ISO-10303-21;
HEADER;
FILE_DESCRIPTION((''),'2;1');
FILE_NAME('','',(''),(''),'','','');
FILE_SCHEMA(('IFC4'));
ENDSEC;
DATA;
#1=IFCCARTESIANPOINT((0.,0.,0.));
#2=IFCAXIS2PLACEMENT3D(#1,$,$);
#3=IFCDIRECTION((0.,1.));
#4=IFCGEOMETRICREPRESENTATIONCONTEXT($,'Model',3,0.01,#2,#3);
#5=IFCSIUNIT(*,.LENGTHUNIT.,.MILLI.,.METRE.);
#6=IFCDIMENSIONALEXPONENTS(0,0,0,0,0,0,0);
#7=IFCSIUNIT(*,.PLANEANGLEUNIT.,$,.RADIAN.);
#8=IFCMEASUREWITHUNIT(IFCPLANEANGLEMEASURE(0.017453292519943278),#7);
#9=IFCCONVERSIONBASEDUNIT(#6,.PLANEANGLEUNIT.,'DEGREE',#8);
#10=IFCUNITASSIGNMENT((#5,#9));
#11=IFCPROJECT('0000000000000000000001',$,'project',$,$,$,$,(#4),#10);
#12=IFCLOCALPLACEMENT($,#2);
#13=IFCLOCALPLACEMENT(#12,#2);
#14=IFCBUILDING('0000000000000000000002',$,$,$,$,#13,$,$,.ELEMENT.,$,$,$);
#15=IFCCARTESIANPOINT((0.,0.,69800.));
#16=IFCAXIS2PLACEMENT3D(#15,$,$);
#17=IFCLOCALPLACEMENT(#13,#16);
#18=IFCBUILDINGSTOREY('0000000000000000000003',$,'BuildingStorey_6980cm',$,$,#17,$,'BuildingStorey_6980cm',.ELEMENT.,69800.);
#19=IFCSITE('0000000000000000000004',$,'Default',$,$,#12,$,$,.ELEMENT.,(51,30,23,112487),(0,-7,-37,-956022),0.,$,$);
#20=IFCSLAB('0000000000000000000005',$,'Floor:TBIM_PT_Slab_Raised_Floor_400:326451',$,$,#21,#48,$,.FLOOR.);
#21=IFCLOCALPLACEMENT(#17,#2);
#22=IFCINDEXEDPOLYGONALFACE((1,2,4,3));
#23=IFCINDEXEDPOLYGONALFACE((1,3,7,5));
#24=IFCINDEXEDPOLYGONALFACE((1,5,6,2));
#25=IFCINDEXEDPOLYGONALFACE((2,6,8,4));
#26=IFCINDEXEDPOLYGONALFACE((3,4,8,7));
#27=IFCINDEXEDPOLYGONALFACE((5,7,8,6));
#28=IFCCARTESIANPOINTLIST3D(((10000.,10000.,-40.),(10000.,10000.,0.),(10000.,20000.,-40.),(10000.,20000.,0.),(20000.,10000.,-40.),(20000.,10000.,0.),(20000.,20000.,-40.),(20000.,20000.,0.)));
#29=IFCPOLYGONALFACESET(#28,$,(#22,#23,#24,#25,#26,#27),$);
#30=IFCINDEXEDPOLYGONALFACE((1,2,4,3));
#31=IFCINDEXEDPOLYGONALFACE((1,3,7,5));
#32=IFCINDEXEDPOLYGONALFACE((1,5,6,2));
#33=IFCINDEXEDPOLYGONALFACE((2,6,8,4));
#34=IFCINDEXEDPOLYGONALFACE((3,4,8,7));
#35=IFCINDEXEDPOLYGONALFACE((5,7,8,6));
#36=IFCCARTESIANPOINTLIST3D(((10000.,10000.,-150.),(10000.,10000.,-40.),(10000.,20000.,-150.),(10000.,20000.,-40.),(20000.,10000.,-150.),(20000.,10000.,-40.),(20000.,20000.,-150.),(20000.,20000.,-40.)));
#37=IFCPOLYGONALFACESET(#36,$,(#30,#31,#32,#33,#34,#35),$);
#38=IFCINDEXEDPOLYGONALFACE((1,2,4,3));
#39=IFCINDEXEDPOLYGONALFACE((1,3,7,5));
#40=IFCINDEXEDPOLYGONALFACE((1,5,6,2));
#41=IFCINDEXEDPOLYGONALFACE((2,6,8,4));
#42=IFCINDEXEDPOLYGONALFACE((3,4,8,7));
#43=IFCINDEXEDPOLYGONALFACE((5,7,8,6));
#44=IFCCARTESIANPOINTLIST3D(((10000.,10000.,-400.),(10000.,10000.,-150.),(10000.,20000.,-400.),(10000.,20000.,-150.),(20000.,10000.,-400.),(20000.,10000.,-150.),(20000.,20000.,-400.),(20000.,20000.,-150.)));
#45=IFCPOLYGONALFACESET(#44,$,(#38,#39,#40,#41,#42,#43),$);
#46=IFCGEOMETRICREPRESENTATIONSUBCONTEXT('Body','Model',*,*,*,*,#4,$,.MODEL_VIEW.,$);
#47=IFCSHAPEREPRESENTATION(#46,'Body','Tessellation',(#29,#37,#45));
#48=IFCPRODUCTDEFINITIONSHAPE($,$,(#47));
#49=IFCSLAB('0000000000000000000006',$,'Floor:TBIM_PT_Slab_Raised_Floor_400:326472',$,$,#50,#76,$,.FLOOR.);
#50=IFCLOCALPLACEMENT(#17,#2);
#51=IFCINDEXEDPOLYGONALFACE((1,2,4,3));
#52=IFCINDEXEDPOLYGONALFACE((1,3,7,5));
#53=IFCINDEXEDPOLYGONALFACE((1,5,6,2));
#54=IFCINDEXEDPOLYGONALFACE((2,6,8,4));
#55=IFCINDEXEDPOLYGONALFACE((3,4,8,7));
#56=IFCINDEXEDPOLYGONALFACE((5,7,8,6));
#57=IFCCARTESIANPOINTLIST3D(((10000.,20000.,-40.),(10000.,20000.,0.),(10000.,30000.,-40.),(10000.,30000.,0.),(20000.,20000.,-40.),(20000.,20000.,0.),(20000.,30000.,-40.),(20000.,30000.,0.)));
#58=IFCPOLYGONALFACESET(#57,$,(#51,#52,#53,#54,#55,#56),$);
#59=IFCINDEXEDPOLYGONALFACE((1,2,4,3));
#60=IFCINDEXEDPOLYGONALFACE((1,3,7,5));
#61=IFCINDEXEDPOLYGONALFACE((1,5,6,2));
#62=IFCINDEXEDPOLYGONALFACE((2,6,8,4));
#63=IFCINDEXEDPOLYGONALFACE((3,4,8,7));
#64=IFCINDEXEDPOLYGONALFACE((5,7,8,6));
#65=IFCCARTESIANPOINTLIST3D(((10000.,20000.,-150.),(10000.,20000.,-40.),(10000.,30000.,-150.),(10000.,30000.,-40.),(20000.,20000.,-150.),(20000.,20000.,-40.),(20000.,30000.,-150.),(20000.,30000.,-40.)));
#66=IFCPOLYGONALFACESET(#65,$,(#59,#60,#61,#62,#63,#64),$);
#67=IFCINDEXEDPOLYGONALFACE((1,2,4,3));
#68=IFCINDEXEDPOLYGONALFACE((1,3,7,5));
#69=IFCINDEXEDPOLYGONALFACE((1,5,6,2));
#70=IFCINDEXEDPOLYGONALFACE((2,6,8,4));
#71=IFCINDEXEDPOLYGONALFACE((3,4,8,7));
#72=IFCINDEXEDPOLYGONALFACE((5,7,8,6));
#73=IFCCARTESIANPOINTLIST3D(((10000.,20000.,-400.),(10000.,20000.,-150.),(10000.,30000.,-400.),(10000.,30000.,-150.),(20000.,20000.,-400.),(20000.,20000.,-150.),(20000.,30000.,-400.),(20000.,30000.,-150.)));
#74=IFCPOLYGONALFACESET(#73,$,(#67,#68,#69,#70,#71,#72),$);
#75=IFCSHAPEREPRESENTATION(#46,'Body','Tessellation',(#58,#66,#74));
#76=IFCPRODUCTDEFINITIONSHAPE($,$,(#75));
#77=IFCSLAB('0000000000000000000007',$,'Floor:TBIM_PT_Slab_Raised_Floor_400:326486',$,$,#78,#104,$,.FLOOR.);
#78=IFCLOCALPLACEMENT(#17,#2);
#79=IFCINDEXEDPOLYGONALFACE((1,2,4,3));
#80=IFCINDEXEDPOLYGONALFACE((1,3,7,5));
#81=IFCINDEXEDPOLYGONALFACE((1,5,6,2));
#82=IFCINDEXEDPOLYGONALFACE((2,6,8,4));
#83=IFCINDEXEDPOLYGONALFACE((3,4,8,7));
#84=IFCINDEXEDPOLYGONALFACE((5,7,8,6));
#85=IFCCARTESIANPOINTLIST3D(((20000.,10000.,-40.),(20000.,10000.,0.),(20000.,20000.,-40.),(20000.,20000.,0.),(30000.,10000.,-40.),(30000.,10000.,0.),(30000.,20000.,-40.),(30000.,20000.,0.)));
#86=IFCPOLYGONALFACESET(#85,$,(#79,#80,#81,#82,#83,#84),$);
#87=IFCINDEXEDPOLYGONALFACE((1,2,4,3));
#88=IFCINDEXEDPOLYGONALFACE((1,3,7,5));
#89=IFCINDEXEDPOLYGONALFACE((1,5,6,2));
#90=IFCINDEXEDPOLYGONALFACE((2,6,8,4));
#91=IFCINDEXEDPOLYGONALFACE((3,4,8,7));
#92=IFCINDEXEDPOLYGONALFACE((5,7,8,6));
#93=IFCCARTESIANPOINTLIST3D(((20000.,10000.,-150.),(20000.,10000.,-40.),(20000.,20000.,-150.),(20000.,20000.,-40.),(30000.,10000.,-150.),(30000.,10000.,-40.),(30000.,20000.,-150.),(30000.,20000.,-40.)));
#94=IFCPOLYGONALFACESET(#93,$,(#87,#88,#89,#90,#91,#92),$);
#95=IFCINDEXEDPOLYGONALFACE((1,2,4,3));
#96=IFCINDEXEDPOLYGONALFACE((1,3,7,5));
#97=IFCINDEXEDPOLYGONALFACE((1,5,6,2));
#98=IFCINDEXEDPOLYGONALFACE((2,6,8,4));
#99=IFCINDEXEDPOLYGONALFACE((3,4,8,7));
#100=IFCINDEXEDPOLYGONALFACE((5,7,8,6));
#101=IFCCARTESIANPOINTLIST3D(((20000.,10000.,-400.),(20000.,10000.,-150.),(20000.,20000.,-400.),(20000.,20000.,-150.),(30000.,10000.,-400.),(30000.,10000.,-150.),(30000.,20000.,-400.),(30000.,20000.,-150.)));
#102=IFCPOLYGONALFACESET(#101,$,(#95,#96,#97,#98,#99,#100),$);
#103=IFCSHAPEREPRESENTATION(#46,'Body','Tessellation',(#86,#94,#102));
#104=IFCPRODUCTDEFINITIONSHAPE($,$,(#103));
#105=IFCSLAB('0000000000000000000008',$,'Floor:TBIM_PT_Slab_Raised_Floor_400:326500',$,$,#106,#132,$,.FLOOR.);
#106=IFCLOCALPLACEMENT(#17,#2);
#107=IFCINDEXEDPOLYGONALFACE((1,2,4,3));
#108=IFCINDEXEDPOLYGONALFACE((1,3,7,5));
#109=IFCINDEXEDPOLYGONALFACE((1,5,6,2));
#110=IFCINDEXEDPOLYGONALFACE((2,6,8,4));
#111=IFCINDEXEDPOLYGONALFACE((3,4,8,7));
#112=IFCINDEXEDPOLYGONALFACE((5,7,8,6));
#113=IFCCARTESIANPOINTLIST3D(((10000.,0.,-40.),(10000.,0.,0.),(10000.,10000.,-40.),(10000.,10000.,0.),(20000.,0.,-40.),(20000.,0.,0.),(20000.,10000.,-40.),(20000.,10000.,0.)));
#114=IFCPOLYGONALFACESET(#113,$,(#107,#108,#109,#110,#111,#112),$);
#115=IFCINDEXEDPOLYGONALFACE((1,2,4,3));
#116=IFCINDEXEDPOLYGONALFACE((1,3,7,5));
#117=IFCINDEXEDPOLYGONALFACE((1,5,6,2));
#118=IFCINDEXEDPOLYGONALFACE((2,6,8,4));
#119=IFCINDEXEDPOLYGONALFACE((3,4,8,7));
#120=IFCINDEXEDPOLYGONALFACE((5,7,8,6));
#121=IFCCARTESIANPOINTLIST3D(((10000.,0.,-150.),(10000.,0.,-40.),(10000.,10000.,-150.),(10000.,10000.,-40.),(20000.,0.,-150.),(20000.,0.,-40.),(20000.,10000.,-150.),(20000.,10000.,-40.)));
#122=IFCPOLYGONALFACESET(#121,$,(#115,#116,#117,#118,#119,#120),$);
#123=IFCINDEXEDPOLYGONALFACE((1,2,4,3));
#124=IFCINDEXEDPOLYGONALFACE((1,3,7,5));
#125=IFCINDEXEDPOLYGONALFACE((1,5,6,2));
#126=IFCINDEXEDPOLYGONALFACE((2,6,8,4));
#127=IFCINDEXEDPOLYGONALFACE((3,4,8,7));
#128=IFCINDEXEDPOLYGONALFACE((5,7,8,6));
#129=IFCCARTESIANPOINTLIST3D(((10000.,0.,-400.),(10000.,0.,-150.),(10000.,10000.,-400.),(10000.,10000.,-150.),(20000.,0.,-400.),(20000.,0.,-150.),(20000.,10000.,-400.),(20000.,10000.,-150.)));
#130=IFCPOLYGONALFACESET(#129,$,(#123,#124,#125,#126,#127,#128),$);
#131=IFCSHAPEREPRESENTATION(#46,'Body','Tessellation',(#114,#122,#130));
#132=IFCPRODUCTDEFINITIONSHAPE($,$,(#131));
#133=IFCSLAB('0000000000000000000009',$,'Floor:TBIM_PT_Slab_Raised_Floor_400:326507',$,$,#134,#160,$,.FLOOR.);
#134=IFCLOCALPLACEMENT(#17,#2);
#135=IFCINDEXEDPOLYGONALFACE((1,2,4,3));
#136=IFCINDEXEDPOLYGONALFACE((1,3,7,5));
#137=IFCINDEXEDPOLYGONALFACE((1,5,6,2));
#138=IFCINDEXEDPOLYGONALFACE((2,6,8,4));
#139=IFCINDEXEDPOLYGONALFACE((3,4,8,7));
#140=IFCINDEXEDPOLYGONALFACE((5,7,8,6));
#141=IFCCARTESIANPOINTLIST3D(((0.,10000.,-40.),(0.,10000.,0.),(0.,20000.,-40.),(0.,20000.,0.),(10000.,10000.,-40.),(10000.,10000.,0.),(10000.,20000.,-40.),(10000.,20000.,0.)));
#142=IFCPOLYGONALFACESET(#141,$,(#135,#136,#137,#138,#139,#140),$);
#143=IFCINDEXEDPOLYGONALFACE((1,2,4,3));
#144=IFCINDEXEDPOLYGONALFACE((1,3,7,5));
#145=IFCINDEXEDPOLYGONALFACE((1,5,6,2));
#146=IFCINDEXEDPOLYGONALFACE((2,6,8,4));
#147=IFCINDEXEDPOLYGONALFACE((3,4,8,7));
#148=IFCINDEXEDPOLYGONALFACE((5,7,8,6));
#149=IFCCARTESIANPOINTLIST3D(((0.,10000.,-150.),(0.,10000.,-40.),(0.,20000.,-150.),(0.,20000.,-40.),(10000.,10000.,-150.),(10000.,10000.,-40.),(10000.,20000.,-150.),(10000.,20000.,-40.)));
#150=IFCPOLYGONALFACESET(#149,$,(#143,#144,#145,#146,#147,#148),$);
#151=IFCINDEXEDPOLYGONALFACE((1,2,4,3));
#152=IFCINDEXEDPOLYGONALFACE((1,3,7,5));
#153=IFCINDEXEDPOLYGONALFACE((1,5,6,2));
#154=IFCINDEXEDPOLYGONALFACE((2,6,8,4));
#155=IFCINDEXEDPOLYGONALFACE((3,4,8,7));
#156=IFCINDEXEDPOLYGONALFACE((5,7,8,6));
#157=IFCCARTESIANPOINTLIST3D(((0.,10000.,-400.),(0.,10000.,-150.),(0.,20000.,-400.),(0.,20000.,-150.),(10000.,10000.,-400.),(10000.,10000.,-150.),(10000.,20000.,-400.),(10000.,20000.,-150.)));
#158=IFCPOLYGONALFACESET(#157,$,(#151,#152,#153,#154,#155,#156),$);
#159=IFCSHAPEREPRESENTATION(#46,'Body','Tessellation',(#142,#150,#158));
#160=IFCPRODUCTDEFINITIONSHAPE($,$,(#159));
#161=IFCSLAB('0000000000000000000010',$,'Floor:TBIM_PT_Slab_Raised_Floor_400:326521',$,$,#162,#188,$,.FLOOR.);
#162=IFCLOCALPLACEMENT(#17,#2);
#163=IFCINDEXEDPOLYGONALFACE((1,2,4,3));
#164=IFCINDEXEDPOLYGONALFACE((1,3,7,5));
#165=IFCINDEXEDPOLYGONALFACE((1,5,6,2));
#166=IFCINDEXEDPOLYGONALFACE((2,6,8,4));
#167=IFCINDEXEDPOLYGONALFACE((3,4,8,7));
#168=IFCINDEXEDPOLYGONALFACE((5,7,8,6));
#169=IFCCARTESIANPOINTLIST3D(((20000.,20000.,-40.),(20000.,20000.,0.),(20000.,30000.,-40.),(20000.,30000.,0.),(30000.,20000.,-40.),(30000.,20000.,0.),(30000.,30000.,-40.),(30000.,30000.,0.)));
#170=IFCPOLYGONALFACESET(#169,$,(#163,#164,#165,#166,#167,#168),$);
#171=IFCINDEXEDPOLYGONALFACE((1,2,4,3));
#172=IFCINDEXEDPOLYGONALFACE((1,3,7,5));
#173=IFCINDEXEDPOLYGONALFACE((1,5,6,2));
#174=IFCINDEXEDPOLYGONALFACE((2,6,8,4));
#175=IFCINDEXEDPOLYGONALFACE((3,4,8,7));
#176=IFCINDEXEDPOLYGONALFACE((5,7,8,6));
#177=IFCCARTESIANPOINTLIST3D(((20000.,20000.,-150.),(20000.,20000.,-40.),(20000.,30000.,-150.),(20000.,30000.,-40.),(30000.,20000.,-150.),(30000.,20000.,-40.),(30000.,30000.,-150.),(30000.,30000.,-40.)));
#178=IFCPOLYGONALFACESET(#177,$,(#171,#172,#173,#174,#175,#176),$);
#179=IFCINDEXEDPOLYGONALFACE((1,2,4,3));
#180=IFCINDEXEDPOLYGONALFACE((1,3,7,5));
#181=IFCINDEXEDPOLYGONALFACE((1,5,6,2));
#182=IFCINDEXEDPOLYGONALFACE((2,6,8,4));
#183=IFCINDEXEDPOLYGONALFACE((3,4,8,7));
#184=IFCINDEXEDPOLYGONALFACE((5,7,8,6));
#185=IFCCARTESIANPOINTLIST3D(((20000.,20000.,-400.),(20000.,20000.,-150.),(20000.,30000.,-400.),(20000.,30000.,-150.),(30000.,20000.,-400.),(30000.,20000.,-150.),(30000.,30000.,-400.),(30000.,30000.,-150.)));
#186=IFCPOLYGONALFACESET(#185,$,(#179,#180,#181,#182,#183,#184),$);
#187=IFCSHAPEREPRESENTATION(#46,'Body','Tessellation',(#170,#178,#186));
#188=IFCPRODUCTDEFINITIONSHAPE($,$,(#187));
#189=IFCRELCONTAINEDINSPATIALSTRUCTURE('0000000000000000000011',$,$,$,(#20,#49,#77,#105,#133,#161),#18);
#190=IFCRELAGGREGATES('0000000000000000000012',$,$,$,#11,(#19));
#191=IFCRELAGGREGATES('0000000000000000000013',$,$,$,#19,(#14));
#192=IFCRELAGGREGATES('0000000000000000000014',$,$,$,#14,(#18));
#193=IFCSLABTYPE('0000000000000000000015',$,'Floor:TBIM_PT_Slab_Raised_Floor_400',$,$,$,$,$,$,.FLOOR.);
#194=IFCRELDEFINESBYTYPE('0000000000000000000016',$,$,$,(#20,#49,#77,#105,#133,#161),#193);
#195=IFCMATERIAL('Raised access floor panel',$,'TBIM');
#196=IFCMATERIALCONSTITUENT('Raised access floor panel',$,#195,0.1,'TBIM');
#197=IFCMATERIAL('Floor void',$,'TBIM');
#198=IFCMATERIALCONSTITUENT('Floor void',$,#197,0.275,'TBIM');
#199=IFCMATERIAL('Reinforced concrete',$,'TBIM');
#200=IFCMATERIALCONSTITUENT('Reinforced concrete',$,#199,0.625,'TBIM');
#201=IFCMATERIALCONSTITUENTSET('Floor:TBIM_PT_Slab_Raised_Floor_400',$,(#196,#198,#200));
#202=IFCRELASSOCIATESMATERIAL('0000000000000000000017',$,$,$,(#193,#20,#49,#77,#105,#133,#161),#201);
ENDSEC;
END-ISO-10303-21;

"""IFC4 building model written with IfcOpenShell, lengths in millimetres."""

from ifc_helpers import new_model, entity, si_unit, converted_unit, direction, frame, origin, place, context, subcontext, project, spatial, indexed_curve, outline, extrude, material, constituent, constituent_set, type_object, element, save


model = new_model("IFC4")

# Units and contexts
model_context = context("Model", 3, precision=0.01, world=origin(), true_north=direction((0.0, 1.0)))
body_context = subcontext(model_context, "Body", "Model", "MODEL_VIEW")
ifc_project = project(units=[si_unit("LENGTHUNIT", "METRE", prefix="MILLI"), converted_unit("PLANEANGLEUNIT", "DEGREE", entity("IfcPlaneAngleMeasure", 0.017453292519943278), si_unit("PLANEANGLEUNIT", "RADIAN"), dimensions=[0, 0, 0, 0, 0, 0, 0])], contexts=[model_context])

# Site, building, storey
site_placement = place(None, origin())
site = spatial("IfcSite", under=ifc_project, at=site_placement, Name="Default", CompositionType="ELEMENT", RefLatitude=(51, 30, 23, 112487), RefLongitude=(0, -7, -37, -956022), RefElevation=0.0)
building_placement = place(site_placement, origin())
building = spatial("IfcBuilding", under=site, at=building_placement, CompositionType="ELEMENT")
storey_placement = place(building_placement, frame((0.0, 0.0, 69800.0)))
storey = spatial("IfcBuildingStorey", under=building, at=storey_placement, Name="BuildingStorey_6980cm", LongName="BuildingStorey_6980cm", CompositionType="ELEMENT", Elevation=69800.0)

# Slabs
ifc_material_1 = material(Name="Raised access floor panel", Category="TBIM")
ifc_constituent_1 = constituent(ifc_material_1, Name="Raised access floor panel", Category="TBIM", fraction=0.1)
ifc_material_2 = material(Name="Floor void", Category="TBIM")
ifc_constituent_2 = constituent(ifc_material_2, Name="Floor void", Category="TBIM", fraction=0.275)
ifc_material_3 = material(Name="Reinforced concrete", Category="TBIM")
ifc_constituent_3 = constituent(ifc_material_3, Name="Reinforced concrete", Category="TBIM", fraction=0.625)
ifc_constituent_set_1 = constituent_set(constituents=[ifc_constituent_1, ifc_constituent_2, ifc_constituent_3], Name="Floor:TBIM_PT_Slab_Raised_Floor_400")
slab_type = type_object("IfcSlabType", Name="Floor:TBIM_PT_Slab_Raised_Floor_400", PredefinedType="FLOOR", material=ifc_constituent_set_1)
slab_1_placement = place(storey_placement, origin())
element("IfcSlab", 1, at=slab_1_placement, inside=storey, type_object=slab_type, material=ifc_constituent_set_1, Name="Floor:TBIM_PT_Slab_Raised_Floor_400:326451", PredefinedType="FLOOR", context=body_context, shape_type="SweptSolid", body=[
    extrude(outline(indexed_curve([(-5000.0, -5000.0), (5000.0, -5000.0), (5000.0, 5000.0), (-5000.0, 5000.0), (-5000.0, -5000.0)], self_intersect=False)), frame((15000.0, 15000.0, -40.0), z_axis=(0.0, 0.0, 1.0), x_axis=(-1.0, 0.0, 0.0)), (0.0, 0.0, 1.0), 40.0),
    extrude(outline(indexed_curve([(-5000.0, -5000.0), (5000.0, -5000.0), (5000.0, 5000.0), (-5000.0, 5000.0), (-5000.0, -5000.0)], self_intersect=False)), frame((15000.0, 15000.0, -150.0), z_axis=(0.0, 0.0, 1.0), x_axis=(-1.0, 0.0, 0.0)), (0.0, 0.0, 1.0), 110.0),
    extrude(outline(indexed_curve([(-5000.0, -5000.0), (5000.0, -5000.0), (5000.0, 5000.0), (-5000.0, 5000.0), (-5000.0, -5000.0)], self_intersect=False)), frame((15000.0, 15000.0, -400.0), z_axis=(0.0, 0.0, 1.0), x_axis=(-1.0, 0.0, 0.0)), (0.0, 0.0, 1.0), 250.0),
])
slab_2_placement = place(storey_placement, origin())
element("IfcSlab", 2, at=slab_2_placement, inside=storey, type_object=slab_type, material=ifc_constituent_set_1, Name="Floor:TBIM_PT_Slab_Raised_Floor_400:326472", PredefinedType="FLOOR", context=body_context, shape_type="SweptSolid", body=[
    extrude(outline(indexed_curve([(-5000.0, -5000.0), (5000.0, -5000.0), (5000.0, 5000.0), (-5000.0, 5000.0), (-5000.0, -5000.0)], self_intersect=False)), frame((15000.0, 25000.0, -40.0), z_axis=(0.0, 0.0, 1.0), x_axis=(-1.0, 0.0, 0.0)), (0.0, 0.0, 1.0), 40.0),
    extrude(outline(indexed_curve([(-5000.0, -5000.0), (5000.0, -5000.0), (5000.0, 5000.0), (-5000.0, 5000.0), (-5000.0, -5000.0)], self_intersect=False)), frame((15000.0, 25000.0, -150.0), z_axis=(0.0, 0.0, 1.0), x_axis=(-1.0, 0.0, 0.0)), (0.0, 0.0, 1.0), 110.0),
    extrude(outline(indexed_curve([(-5000.0, -5000.0), (5000.0, -5000.0), (5000.0, 5000.0), (-5000.0, 5000.0), (-5000.0, -5000.0)], self_intersect=False)), frame((15000.0, 25000.0, -400.0), z_axis=(0.0, 0.0, 1.0), x_axis=(-1.0, 0.0, 0.0)), (0.0, 0.0, 1.0), 250.0),
])
slab_3_placement = place(storey_placement, origin())
element("IfcSlab", 3, at=slab_3_placement, inside=storey, type_object=slab_type, material=ifc_constituent_set_1, Name="Floor:TBIM_PT_Slab_Raised_Floor_400:326486", PredefinedType="FLOOR", context=body_context, shape_type="SweptSolid", body=[
    extrude(outline(indexed_curve([(-5000.0, -5000.0), (5000.0, -5000.0), (5000.0, 5000.0), (-5000.0, 5000.0), (-5000.0, -5000.0)], self_intersect=False)), frame((25000.0, 15000.0, -40.0), z_axis=(0.0, 0.0, 1.0), x_axis=(-1.0, 0.0, 0.0)), (0.0, 0.0, 1.0), 40.0),
    extrude(outline(indexed_curve([(-5000.0, -5000.0), (5000.0, -5000.0), (5000.0, 5000.0), (-5000.0, 5000.0), (-5000.0, -5000.0)], self_intersect=False)), frame((25000.0, 15000.0, -150.0), z_axis=(0.0, 0.0, 1.0), x_axis=(-1.0, 0.0, 0.0)), (0.0, 0.0, 1.0), 110.0),
    extrude(outline(indexed_curve([(-5000.0, -5000.0), (5000.0, -5000.0), (5000.0, 5000.0), (-5000.0, 5000.0), (-5000.0, -5000.0)], self_intersect=False)), frame((25000.0, 15000.0, -400.0), z_axis=(0.0, 0.0, 1.0), x_axis=(-1.0, 0.0, 0.0)), (0.0, 0.0, 1.0), 250.0),
])
slab_4_placement = place(storey_placement, origin())
element("IfcSlab", 4, at=slab_4_placement, inside=storey, type_object=slab_type, material=ifc_constituent_set_1, Name="Floor:TBIM_PT_Slab_Raised_Floor_400:326500", PredefinedType="FLOOR", context=body_context, shape_type="SweptSolid", body=[
    extrude(outline(indexed_curve([(-5000.0, -5000.0), (5000.0, -5000.0), (5000.0, 5000.0), (-5000.0, 5000.0), (-5000.0, -5000.0)], self_intersect=False)), frame((15000.0, 5000.0, -40.0), z_axis=(0.0, 0.0, 1.0), x_axis=(0.0, 1.0, 0.0)), (0.0, 0.0, 1.0), 40.0),
    extrude(outline(indexed_curve([(-5000.0, -5000.0), (5000.0, -5000.0), (5000.0, 5000.0), (-5000.0, 5000.0), (-5000.0, -5000.0)], self_intersect=False)), frame((15000.0, 5000.0, -150.0), z_axis=(0.0, 0.0, 1.0), x_axis=(0.0, 1.0, 0.0)), (0.0, 0.0, 1.0), 110.0),
    extrude(outline(indexed_curve([(-5000.0, -5000.0), (5000.0, -5000.0), (5000.0, 5000.0), (-5000.0, 5000.0), (-5000.0, -5000.0)], self_intersect=False)), frame((15000.0, 5000.0, -400.0), z_axis=(0.0, 0.0, 1.0), x_axis=(0.0, 1.0, 0.0)), (0.0, 0.0, 1.0), 250.0),
])
slab_5_placement = place(storey_placement, origin())
element("IfcSlab", 5, at=slab_5_placement, inside=storey, type_object=slab_type, material=ifc_constituent_set_1, Name="Floor:TBIM_PT_Slab_Raised_Floor_400:326507", PredefinedType="FLOOR", context=body_context, shape_type="SweptSolid", body=[
    extrude(outline(indexed_curve([(-5000.0, -5000.0), (5000.0, -5000.0), (5000.0, 5000.0), (-5000.0, 5000.0), (-5000.0, -5000.0)], self_intersect=False)), frame((5000.0, 15000.0, -40.0), z_axis=(0.0, 0.0, 1.0), x_axis=(0.0, 1.0, 0.0)), (0.0, 0.0, 1.0), 40.0),
    extrude(outline(indexed_curve([(-5000.0, -5000.0), (5000.0, -5000.0), (5000.0, 5000.0), (-5000.0, 5000.0), (-5000.0, -5000.0)], self_intersect=False)), frame((5000.0, 15000.0, -150.0), z_axis=(0.0, 0.0, 1.0), x_axis=(0.0, 1.0, 0.0)), (0.0, 0.0, 1.0), 110.0),
    extrude(outline(indexed_curve([(-5000.0, -5000.0), (5000.0, -5000.0), (5000.0, 5000.0), (-5000.0, 5000.0), (-5000.0, -5000.0)], self_intersect=False)), frame((5000.0, 15000.0, -400.0), z_axis=(0.0, 0.0, 1.0), x_axis=(0.0, 1.0, 0.0)), (0.0, 0.0, 1.0), 250.0),
])
slab_6_placement = place(storey_placement, origin())
element("IfcSlab", 6, at=slab_6_placement, inside=storey, type_object=slab_type, material=ifc_constituent_set_1, Name="Floor:TBIM_PT_Slab_Raised_Floor_400:326521", PredefinedType="FLOOR", context=body_context, shape_type="SweptSolid", body=[
    extrude(outline(indexed_curve([(-5000.0, -5000.0), (5000.0, -5000.0), (5000.0, 5000.0), (-5000.0, 5000.0), (-5000.0, -5000.0)], self_intersect=False)), frame((25000.0, 25000.0, -40.0), z_axis=(0.0, 0.0, 1.0), x_axis=(-1.0, 0.0, 0.0)), (0.0, 0.0, 1.0), 40.0),
    extrude(outline(indexed_curve([(-5000.0, -5000.0), (5000.0, -5000.0), (5000.0, 5000.0), (-5000.0, 5000.0), (-5000.0, -5000.0)], self_intersect=False)), frame((25000.0, 25000.0, -150.0), z_axis=(0.0, 0.0, 1.0), x_axis=(-1.0, 0.0, 0.0)), (0.0, 0.0, 1.0), 110.0),
    extrude(outline(indexed_curve([(-5000.0, -5000.0), (5000.0, -5000.0), (5000.0, 5000.0), (-5000.0, 5000.0), (-5000.0, -5000.0)], self_intersect=False)), frame((25000.0, 25000.0, -400.0), z_axis=(0.0, 0.0, 1.0), x_axis=(-1.0, 0.0, 0.0)), (0.0, 0.0, 1.0), 250.0),
])

save(model, "model.ifc")
